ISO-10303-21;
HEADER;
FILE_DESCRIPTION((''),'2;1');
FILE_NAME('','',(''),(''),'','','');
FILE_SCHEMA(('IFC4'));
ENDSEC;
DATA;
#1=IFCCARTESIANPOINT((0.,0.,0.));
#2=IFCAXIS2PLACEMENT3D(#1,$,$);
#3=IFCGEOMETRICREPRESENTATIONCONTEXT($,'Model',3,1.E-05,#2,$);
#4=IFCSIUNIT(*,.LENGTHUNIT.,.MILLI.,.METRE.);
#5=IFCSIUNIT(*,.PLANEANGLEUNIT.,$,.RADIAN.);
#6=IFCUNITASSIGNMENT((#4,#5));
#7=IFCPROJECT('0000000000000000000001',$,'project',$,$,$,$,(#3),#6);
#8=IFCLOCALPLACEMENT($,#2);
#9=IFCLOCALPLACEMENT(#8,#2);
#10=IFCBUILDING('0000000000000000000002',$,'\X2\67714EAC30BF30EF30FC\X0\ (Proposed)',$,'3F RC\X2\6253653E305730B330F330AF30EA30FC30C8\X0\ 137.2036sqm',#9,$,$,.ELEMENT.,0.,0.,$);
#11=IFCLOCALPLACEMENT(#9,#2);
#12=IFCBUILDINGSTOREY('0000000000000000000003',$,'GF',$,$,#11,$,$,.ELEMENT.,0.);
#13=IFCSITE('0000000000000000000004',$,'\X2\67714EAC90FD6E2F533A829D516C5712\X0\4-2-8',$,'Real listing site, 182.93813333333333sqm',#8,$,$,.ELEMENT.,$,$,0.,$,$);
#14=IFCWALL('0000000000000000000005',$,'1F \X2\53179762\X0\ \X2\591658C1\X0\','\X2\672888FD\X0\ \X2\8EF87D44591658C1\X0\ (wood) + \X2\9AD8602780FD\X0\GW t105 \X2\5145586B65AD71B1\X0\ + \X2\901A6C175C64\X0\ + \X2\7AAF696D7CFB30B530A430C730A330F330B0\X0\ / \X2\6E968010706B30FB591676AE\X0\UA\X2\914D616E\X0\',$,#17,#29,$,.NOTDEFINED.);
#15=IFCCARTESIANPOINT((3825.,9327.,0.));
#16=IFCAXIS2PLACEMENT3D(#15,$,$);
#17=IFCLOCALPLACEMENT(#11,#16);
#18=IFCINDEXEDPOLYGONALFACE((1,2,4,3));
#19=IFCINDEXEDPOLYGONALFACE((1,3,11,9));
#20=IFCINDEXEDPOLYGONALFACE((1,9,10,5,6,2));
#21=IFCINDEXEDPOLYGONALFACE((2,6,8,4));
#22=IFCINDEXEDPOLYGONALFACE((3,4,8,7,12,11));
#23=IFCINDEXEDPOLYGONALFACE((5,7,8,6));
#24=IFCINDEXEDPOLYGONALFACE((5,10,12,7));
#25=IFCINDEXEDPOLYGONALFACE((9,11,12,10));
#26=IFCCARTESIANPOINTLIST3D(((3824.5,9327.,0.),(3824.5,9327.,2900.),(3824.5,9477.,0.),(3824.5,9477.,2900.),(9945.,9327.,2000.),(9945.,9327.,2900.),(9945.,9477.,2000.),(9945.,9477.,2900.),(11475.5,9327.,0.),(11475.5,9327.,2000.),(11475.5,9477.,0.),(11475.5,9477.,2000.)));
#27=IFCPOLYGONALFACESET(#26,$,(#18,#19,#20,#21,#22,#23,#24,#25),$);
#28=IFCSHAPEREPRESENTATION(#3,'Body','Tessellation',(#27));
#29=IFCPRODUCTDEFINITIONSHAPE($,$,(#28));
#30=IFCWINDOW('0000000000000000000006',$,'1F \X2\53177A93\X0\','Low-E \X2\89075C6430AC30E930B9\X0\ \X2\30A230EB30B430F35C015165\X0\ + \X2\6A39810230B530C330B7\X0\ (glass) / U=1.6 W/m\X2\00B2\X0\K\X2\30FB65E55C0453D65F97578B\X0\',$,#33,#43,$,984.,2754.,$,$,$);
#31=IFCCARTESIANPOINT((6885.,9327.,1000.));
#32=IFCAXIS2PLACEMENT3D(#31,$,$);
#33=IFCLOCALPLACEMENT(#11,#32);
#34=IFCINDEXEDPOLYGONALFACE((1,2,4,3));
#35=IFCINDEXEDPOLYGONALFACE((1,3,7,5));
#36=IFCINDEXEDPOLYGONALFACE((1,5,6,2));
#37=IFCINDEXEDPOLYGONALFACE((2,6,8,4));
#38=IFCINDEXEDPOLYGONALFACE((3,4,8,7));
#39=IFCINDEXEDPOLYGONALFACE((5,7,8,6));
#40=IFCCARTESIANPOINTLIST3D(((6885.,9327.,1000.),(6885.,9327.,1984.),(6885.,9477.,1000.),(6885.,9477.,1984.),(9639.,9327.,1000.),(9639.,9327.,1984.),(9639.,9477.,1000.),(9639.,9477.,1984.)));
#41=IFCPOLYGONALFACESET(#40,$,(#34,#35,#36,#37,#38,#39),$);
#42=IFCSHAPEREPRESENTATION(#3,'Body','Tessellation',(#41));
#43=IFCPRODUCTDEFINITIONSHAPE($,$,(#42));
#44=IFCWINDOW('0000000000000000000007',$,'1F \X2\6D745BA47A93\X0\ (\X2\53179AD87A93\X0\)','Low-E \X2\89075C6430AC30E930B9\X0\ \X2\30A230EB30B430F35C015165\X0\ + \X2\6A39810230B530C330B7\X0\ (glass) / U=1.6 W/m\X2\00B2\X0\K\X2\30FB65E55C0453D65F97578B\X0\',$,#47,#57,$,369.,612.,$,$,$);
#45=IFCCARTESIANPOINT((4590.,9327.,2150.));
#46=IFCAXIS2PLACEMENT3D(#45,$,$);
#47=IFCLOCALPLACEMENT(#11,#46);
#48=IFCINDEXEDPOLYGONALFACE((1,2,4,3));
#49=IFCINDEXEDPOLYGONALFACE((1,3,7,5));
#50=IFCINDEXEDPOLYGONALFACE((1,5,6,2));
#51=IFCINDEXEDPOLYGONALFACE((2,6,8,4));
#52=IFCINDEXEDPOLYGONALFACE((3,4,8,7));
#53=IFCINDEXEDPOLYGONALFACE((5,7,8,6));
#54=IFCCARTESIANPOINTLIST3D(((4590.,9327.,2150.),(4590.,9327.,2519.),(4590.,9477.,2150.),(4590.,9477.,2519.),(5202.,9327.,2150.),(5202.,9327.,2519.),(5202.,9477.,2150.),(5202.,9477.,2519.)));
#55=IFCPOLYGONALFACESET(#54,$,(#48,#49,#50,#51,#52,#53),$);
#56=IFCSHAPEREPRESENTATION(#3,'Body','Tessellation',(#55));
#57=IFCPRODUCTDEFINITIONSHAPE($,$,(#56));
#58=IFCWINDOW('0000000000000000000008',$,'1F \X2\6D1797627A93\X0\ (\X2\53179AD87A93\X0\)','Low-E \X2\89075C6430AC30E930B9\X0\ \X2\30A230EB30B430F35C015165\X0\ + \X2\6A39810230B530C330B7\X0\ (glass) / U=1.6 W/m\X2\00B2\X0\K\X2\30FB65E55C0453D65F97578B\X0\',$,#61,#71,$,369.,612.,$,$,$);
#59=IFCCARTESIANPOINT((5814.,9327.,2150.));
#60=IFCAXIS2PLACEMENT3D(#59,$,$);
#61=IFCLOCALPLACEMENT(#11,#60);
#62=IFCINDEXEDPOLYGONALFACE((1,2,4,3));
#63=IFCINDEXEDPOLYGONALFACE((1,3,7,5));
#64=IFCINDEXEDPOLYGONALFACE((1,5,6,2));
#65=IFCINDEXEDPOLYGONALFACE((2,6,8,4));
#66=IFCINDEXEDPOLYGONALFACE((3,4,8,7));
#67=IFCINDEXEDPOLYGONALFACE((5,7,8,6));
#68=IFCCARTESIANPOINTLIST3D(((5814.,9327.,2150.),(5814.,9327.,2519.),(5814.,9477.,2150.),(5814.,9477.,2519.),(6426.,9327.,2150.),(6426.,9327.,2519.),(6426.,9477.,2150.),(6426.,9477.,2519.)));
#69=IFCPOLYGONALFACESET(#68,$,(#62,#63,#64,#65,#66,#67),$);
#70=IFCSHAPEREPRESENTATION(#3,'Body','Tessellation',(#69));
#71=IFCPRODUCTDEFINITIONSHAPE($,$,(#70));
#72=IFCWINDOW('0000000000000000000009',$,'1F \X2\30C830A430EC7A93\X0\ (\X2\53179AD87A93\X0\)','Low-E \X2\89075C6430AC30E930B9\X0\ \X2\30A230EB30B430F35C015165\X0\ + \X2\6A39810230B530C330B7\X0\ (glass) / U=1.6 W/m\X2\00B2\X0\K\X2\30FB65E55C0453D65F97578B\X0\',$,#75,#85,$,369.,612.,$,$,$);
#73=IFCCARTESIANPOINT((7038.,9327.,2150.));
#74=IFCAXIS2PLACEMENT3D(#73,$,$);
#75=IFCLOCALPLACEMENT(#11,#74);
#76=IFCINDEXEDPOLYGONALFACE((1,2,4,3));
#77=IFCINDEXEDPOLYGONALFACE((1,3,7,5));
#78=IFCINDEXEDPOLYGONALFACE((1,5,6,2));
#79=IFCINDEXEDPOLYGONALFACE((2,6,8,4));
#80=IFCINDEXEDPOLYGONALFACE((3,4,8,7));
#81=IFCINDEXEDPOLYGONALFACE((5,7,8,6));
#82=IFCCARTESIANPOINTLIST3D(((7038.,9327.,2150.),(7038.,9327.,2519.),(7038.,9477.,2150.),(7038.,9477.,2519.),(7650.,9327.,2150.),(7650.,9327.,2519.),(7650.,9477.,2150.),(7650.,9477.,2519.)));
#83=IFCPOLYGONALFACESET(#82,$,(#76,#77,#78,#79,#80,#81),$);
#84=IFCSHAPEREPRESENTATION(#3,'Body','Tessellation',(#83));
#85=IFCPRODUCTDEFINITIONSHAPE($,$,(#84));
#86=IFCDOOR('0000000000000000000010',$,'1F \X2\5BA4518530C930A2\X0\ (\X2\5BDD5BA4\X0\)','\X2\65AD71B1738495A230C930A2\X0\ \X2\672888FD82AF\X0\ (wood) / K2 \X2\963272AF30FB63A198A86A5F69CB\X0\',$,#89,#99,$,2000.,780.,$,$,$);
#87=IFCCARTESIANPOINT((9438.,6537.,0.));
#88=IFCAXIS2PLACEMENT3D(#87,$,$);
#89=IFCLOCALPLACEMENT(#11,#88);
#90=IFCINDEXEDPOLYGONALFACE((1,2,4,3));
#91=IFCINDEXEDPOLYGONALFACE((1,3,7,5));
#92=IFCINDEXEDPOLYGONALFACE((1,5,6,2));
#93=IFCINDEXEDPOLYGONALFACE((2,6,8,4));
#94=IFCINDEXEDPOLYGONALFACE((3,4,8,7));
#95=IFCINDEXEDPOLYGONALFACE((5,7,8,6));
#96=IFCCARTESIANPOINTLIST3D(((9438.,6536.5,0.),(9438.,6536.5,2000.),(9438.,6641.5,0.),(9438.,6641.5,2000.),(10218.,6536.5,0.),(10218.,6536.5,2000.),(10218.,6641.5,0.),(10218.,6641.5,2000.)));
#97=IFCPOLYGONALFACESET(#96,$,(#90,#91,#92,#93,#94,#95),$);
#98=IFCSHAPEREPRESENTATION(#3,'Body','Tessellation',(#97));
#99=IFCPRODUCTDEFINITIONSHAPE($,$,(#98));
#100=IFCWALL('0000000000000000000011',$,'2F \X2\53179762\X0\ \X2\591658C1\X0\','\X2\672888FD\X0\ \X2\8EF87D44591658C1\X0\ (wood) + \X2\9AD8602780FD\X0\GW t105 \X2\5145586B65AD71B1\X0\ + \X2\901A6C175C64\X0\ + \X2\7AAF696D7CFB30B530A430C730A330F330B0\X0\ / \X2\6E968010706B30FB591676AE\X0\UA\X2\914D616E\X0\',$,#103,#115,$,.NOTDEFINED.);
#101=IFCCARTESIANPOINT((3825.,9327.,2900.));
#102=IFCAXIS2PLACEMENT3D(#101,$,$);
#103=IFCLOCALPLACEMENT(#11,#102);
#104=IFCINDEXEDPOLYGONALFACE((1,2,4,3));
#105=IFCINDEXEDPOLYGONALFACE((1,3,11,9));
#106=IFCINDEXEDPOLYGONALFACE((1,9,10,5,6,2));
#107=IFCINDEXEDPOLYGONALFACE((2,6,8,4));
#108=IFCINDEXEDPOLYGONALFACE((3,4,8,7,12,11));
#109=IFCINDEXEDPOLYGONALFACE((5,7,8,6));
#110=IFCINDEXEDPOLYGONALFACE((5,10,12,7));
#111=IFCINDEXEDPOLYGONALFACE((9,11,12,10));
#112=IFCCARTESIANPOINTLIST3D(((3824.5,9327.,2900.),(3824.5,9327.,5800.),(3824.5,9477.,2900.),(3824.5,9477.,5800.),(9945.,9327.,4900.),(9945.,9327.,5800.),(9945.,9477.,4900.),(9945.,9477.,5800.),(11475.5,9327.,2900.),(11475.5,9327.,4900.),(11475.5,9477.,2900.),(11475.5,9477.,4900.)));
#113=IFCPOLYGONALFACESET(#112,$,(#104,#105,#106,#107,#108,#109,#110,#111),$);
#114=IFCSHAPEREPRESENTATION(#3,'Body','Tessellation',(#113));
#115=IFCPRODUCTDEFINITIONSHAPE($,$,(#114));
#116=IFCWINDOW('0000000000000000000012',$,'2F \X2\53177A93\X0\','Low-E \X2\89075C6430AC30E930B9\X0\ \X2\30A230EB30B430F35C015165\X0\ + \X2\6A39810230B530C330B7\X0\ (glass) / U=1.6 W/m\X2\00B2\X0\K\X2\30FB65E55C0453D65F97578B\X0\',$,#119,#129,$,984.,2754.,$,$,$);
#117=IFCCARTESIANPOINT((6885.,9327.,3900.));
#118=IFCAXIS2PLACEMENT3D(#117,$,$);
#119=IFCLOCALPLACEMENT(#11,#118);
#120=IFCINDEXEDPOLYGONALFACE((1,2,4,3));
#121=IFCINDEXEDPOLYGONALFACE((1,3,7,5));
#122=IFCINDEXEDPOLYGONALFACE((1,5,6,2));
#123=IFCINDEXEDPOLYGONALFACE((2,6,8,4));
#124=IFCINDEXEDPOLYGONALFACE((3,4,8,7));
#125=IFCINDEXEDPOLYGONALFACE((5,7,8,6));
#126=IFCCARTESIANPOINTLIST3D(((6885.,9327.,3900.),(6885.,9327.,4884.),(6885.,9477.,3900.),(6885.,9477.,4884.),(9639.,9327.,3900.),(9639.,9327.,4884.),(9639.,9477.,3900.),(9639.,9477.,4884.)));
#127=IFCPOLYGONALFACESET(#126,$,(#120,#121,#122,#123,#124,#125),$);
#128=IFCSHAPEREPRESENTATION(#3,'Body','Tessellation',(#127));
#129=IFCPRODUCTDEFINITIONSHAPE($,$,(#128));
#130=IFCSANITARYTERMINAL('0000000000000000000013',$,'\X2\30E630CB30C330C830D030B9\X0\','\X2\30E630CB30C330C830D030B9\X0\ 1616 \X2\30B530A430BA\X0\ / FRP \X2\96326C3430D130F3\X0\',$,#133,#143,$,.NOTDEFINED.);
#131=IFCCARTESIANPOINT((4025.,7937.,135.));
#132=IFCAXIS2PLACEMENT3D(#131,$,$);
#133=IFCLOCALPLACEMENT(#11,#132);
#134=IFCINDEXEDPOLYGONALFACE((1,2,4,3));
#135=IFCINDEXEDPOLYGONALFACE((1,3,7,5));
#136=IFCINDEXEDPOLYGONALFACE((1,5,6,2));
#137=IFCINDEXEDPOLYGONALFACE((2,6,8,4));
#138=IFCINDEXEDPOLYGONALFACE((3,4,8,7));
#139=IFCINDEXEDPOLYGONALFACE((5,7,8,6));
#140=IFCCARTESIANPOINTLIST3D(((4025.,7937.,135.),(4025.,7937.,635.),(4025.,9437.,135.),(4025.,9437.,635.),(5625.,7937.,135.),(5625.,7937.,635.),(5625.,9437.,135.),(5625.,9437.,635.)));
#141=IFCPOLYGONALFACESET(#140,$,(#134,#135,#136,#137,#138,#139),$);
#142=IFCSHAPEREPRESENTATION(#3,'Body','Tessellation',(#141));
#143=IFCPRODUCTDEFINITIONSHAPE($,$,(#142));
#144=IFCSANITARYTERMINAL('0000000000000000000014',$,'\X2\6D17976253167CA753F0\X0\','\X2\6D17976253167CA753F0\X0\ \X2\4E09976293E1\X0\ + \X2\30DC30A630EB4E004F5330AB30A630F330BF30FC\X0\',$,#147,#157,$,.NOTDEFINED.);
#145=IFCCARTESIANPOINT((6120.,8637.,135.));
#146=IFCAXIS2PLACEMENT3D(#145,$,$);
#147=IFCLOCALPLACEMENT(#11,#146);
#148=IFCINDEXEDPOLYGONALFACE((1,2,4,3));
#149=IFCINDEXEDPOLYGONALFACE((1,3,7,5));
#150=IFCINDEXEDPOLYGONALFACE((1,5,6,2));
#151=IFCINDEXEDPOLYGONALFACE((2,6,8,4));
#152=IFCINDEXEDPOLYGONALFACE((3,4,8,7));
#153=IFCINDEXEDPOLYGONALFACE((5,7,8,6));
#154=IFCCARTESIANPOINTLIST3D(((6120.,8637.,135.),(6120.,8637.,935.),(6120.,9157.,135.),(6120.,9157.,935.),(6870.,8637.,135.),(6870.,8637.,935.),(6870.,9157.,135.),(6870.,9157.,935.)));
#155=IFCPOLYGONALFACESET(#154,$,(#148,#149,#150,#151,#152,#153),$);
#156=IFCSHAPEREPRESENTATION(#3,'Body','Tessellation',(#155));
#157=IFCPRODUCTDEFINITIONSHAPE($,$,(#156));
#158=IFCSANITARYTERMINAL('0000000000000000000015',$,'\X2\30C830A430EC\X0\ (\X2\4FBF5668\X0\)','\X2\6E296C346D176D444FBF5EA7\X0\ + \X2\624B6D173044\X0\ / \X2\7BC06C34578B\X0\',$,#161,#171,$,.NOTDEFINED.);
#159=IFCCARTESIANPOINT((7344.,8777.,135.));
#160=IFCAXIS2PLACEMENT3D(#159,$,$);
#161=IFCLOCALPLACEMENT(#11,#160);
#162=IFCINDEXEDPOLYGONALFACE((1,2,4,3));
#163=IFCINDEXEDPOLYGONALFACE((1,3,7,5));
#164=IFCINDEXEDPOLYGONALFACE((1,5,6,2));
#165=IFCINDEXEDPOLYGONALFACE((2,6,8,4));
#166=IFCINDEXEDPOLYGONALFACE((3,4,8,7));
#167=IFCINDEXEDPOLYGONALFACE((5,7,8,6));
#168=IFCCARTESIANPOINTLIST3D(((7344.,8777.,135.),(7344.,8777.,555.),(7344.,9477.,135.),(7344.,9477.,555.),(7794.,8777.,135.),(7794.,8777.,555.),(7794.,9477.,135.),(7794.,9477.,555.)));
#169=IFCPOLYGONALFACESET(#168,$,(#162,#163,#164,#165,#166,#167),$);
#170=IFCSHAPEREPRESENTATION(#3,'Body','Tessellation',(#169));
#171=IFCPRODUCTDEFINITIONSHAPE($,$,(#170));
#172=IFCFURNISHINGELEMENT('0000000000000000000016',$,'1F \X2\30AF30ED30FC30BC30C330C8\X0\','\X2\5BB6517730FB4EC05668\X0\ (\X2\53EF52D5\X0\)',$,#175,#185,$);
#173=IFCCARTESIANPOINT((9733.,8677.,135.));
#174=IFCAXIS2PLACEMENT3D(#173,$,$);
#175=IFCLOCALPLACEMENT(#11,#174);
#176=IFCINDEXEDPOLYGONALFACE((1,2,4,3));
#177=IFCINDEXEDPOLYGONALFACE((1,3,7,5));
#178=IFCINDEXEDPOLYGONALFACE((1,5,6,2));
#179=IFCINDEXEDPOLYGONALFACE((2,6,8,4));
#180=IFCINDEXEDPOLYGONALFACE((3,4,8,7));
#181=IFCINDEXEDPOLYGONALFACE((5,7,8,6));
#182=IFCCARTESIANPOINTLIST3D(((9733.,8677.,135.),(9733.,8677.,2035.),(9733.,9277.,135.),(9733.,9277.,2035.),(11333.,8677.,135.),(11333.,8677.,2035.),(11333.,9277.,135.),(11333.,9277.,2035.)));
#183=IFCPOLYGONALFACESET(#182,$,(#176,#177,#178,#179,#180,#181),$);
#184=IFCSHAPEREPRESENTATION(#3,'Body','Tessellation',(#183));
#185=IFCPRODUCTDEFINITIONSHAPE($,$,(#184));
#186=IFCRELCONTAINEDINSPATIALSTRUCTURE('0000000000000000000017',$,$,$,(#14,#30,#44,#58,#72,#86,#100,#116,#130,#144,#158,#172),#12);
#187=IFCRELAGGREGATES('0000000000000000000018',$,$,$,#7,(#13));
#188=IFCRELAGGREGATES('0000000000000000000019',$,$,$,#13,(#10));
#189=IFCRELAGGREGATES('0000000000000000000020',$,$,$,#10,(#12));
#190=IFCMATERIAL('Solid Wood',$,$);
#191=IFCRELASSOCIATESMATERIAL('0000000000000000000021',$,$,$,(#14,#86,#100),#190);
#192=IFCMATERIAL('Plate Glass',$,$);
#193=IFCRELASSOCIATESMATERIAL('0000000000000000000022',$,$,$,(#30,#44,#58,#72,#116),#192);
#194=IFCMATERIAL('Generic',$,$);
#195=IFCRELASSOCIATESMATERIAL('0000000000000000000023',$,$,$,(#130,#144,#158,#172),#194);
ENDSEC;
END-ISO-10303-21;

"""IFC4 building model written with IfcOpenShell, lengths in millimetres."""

from ifc_helpers import new_model, si_unit, frame, frame_2d, origin, place, context, project, spatial, rectangle, extrude, material, element, fill, save


model = new_model("IFC4")

# Units and contexts
model_context = context("Model", 3, precision=1e-05, world=origin())
ifc_project = project(units=[si_unit("LENGTHUNIT", "METRE", prefix="MILLI"), si_unit("PLANEANGLEUNIT", "RADIAN")], contexts=[model_context])

# Site, building, storey
site_placement = place(None, origin())
site = spatial("IfcSite", under=ifc_project, at=site_placement, Name="東京都港区芝公園4-2-8", ObjectType="Real listing site, 182.93813333333333sqm", CompositionType="ELEMENT", RefElevation=0.0)
building_placement = place(site_placement, origin())
building = spatial("IfcBuilding", under=site, at=building_placement, Name="東京タワー (Proposed)", ObjectType="3F RC打放しコンクリート 137.2036sqm", CompositionType="ELEMENT", ElevationOfRefHeight=0.0, ElevationOfTerrain=0.0)
storey_placement = place(building_placement, origin())
storey = spatial("IfcBuildingStorey", under=building, at=storey_placement, Name="GF", CompositionType="ELEMENT", Elevation=0.0)

# Wall, openings, windows
ifc_material_1 = material(Name="Solid Wood")
wall_1_placement = place(storey_placement, frame((3825.0, 9327.0, 0.0)))
wall_1 = element("IfcWall", 1, at=wall_1_placement, inside=storey, material=ifc_material_1, Name="1F 北面 外壁", Description="木製 軸組外壁 (wood) + 高性能GW t105 充填断熱 + 通気層 + 窯業系サイディング / 準耐火・外皮UA配慮", PredefinedType="NOTDEFINED", context=model_context, shape_type="SweptSolid", body=[
    extrude(rectangle(XDim=7651.0, YDim=150.0, at=frame_2d((3825.0, 75.0))), frame((3825.0, 9327.0, 0.0)), (0.0, 0.0, 1.0), 2900.0),
])
opening_1_placement = place(storey_placement, frame((6885.0, 9327.0, 1000.0)))
opening_1 = element("IfcOpeningElement", 2, at=opening_1_placement, cuts=wall_1, PredefinedType="NOTDEFINED", context=model_context, shape_type="SweptSolid", body=[
    extrude(rectangle(XDim=2754.0, YDim=150.0, at=frame_2d((1377.0, 75.0))), frame((6885.0, 9327.0, 1000.0)), (0.0, 0.0, 1.0), 984.0),
])
opening_2_placement = place(storey_placement, frame((4590.0, 9327.0, 2150.0)))
opening_2 = element("IfcOpeningElement", 3, at=opening_2_placement, cuts=wall_1, PredefinedType="NOTDEFINED", context=model_context, shape_type="SweptSolid", body=[
    extrude(rectangle(XDim=612.0, YDim=150.0, at=frame_2d((306.0, 75.0))), frame((4590.0, 9327.0, 2150.0)), (0.0, 0.0, 1.0), 369.0),
])
opening_3_placement = place(storey_placement, frame((5814.0, 9327.0, 2150.0)))
opening_3 = element("IfcOpeningElement", 4, at=opening_3_placement, cuts=wall_1, PredefinedType="NOTDEFINED", context=model_context, shape_type="SweptSolid", body=[
    extrude(rectangle(XDim=612.0, YDim=150.0, at=frame_2d((306.0, 75.0))), frame((5814.0, 9327.0, 2150.0)), (0.0, 0.0, 1.0), 369.0),
])
opening_4_placement = place(storey_placement, frame((7038.0, 9327.0, 2150.0)))
opening_4 = element("IfcOpeningElement", 5, at=opening_4_placement, cuts=wall_1, PredefinedType="NOTDEFINED", context=model_context, shape_type="SweptSolid", body=[
    extrude(rectangle(XDim=612.0, YDim=150.0, at=frame_2d((306.0, 75.0))), frame((7038.0, 9327.0, 2150.0)), (0.0, 0.0, 1.0), 369.0),
])
ifc_material_2 = material(Name="Plate Glass")
window_1_placement = place(storey_placement, frame((6885.0, 9327.0, 1000.0)))
window_1 = element("IfcWindow", 6, at=window_1_placement, inside=storey, material=ifc_material_2, Name="1F 北窓", Description="Low-E 複層ガラス アルゴン封入 + 樹脂サッシ (glass) / U=1.6 W/m²K・日射取得型", OverallHeight=984.0, OverallWidth=2754.0, context=model_context, shape_type="SweptSolid", body=[
    extrude(rectangle(XDim=2754.0, YDim=150.0, at=frame_2d((1377.0, 75.0))), frame((6885.0, 9327.0, 1000.0)), (0.0, 0.0, 1.0), 984.0),
])
fill(opening_1, window_1)
window_2_placement = place(storey_placement, frame((4590.0, 9327.0, 2150.0)))
window_2 = element("IfcWindow", 7, at=window_2_placement, inside=storey, material=ifc_material_2, Name="1F 浴室窓 (北高窓)", Description="Low-E 複層ガラス アルゴン封入 + 樹脂サッシ (glass) / U=1.6 W/m²K・日射取得型", OverallHeight=369.0, OverallWidth=612.0, context=model_context, shape_type="SweptSolid", body=[
    extrude(rectangle(XDim=612.0, YDim=150.0, at=frame_2d((306.0, 75.0))), frame((4590.0, 9327.0, 2150.0)), (0.0, 0.0, 1.0), 369.0),
])
fill(opening_2, window_2)
window_3_placement = place(storey_placement, frame((5814.0, 9327.0, 2150.0)))
window_3 = element("IfcWindow", 8, at=window_3_placement, inside=storey, material=ifc_material_2, Name="1F 洗面窓 (北高窓)", Description="Low-E 複層ガラス アルゴン封入 + 樹脂サッシ (glass) / U=1.6 W/m²K・日射取得型", OverallHeight=369.0, OverallWidth=612.0, context=model_context, shape_type="SweptSolid", body=[
    extrude(rectangle(XDim=612.0, YDim=150.0, at=frame_2d((306.0, 75.0))), frame((5814.0, 9327.0, 2150.0)), (0.0, 0.0, 1.0), 369.0),
])
fill(opening_3, window_3)
window_4_placement = place(storey_placement, frame((7038.0, 9327.0, 2150.0)))
window_4 = element("IfcWindow", 9, at=window_4_placement, inside=storey, material=ifc_material_2, Name="1F トイレ窓 (北高窓)", Description="Low-E 複層ガラス アルゴン封入 + 樹脂サッシ (glass) / U=1.6 W/m²K・日射取得型", OverallHeight=369.0, OverallWidth=612.0, context=model_context, shape_type="SweptSolid", body=[
    extrude(rectangle(XDim=612.0, YDim=150.0, at=frame_2d((306.0, 75.0))), frame((7038.0, 9327.0, 2150.0)), (0.0, 0.0, 1.0), 369.0),
])
fill(opening_4, window_4)

# Door
door_1_placement = place(storey_placement, frame((9438.0, 6537.0, 0.0)))
element("IfcDoor", 10, at=door_1_placement, inside=storey, material=ifc_material_1, Name="1F 室内ドア (寝室)", Description="断熱玄関ドア 木製芯 (wood) / K2 防犯・採風機構", OverallHeight=2000.0, OverallWidth=780.0, context=model_context, shape_type="SweptSolid", body=[
    extrude(rectangle(XDim=780.0, YDim=105.0, at=frame_2d((390.0, 52.0))), frame((9438.0, 6537.0, 0.0)), (0.0, 0.0, 1.0), 2000.0),
])

# Wall, opening, window
wall_2_placement = place(storey_placement, frame((3825.0, 9327.0, 2900.0)))
wall_2 = element("IfcWall", 11, at=wall_2_placement, inside=storey, material=ifc_material_1, Name="2F 北面 外壁", Description="木製 軸組外壁 (wood) + 高性能GW t105 充填断熱 + 通気層 + 窯業系サイディング / 準耐火・外皮UA配慮", PredefinedType="NOTDEFINED", context=model_context, shape_type="SweptSolid", body=[
    extrude(rectangle(XDim=7651.0, YDim=150.0, at=frame_2d((3825.0, 75.0))), frame((3825.0, 9327.0, 2900.0)), (0.0, 0.0, 1.0), 2900.0),
])
opening_5_placement = place(storey_placement, frame((6885.0, 9327.0, 3900.0)))
opening_5 = element("IfcOpeningElement", 12, at=opening_5_placement, cuts=wall_2, PredefinedType="NOTDEFINED", context=model_context, shape_type="SweptSolid", body=[
    extrude(rectangle(XDim=2754.0, YDim=150.0, at=frame_2d((1377.0, 75.0))), frame((6885.0, 9327.0, 3900.0)), (0.0, 0.0, 1.0), 984.0),
])
window_5_placement = place(storey_placement, frame((6885.0, 9327.0, 3900.0)))
window_5 = element("IfcWindow", 13, at=window_5_placement, inside=storey, material=ifc_material_2, Name="2F 北窓", Description="Low-E 複層ガラス アルゴン封入 + 樹脂サッシ (glass) / U=1.6 W/m²K・日射取得型", OverallHeight=984.0, OverallWidth=2754.0, context=model_context, shape_type="SweptSolid", body=[
    extrude(rectangle(XDim=2754.0, YDim=150.0, at=frame_2d((1377.0, 75.0))), frame((6885.0, 9327.0, 3900.0)), (0.0, 0.0, 1.0), 984.0),
])
fill(opening_5, window_5)

# Sanitary terminals
ifc_material_3 = material(Name="Generic")
sanitary_terminal_1_placement = place(storey_placement, frame((4025.0, 7937.0, 135.0)))
element("IfcSanitaryTerminal", 14, at=sanitary_terminal_1_placement, inside=storey, material=ifc_material_3, Name="ユニットバス", Description="ユニットバス 1616 サイズ / FRP 防水パン", PredefinedType="NOTDEFINED", context=model_context, shape_type="SweptSolid", body=[
    extrude(rectangle(XDim=1600.0, YDim=1500.0, at=frame_2d((800.0, 750.0))), frame((4025.0, 7937.0, 135.0)), (0.0, 0.0, 1.0), 500.0),
])
sanitary_terminal_2_placement = place(storey_placement, frame((6120.0, 8637.0, 135.0)))
element("IfcSanitaryTerminal", 15, at=sanitary_terminal_2_placement, inside=storey, material=ifc_material_3, Name="洗面化粧台", Description="洗面化粧台 三面鏡 + ボウル一体カウンター", PredefinedType="NOTDEFINED", context=model_context, shape_type="SweptSolid", body=[
    extrude(rectangle(XDim=750.0, YDim=520.0, at=frame_2d((375.0, 260.0))), frame((6120.0, 8637.0, 135.0)), (0.0, 0.0, 1.0), 800.0),
])
sanitary_terminal_3_placement = place(storey_placement, frame((7344.0, 8777.0, 135.0)))
element("IfcSanitaryTerminal", 16, at=sanitary_terminal_3_placement, inside=storey, material=ifc_material_3, Name="トイレ (便器)", Description="温水洗浄便座 + 手洗い / 節水型", PredefinedType="NOTDEFINED", context=model_context, shape_type="SweptSolid", body=[
    extrude(rectangle(XDim=450.0, YDim=700.0, at=frame_2d((225.0, 350.0))), frame((7344.0, 8777.0, 135.0)), (0.0, 0.0, 1.0), 420.0),
])

# Furnishing element
furnishing_1_placement = place(storey_placement, frame((9733.0, 8677.0, 135.0)))
element("IfcFurnishingElement", 17, at=furnishing_1_placement, inside=storey, material=ifc_material_3, Name="1F クローゼット", Description="家具・什器 (可動)", context=model_context, shape_type="SweptSolid", body=[
    extrude(rectangle(XDim=1600.0, YDim=600.0, at=frame_2d((800.0, 300.0))), frame((9733.0, 8677.0, 135.0)), (0.0, 0.0, 1.0), 1900.0),
])

save(model, "model.ifc")
